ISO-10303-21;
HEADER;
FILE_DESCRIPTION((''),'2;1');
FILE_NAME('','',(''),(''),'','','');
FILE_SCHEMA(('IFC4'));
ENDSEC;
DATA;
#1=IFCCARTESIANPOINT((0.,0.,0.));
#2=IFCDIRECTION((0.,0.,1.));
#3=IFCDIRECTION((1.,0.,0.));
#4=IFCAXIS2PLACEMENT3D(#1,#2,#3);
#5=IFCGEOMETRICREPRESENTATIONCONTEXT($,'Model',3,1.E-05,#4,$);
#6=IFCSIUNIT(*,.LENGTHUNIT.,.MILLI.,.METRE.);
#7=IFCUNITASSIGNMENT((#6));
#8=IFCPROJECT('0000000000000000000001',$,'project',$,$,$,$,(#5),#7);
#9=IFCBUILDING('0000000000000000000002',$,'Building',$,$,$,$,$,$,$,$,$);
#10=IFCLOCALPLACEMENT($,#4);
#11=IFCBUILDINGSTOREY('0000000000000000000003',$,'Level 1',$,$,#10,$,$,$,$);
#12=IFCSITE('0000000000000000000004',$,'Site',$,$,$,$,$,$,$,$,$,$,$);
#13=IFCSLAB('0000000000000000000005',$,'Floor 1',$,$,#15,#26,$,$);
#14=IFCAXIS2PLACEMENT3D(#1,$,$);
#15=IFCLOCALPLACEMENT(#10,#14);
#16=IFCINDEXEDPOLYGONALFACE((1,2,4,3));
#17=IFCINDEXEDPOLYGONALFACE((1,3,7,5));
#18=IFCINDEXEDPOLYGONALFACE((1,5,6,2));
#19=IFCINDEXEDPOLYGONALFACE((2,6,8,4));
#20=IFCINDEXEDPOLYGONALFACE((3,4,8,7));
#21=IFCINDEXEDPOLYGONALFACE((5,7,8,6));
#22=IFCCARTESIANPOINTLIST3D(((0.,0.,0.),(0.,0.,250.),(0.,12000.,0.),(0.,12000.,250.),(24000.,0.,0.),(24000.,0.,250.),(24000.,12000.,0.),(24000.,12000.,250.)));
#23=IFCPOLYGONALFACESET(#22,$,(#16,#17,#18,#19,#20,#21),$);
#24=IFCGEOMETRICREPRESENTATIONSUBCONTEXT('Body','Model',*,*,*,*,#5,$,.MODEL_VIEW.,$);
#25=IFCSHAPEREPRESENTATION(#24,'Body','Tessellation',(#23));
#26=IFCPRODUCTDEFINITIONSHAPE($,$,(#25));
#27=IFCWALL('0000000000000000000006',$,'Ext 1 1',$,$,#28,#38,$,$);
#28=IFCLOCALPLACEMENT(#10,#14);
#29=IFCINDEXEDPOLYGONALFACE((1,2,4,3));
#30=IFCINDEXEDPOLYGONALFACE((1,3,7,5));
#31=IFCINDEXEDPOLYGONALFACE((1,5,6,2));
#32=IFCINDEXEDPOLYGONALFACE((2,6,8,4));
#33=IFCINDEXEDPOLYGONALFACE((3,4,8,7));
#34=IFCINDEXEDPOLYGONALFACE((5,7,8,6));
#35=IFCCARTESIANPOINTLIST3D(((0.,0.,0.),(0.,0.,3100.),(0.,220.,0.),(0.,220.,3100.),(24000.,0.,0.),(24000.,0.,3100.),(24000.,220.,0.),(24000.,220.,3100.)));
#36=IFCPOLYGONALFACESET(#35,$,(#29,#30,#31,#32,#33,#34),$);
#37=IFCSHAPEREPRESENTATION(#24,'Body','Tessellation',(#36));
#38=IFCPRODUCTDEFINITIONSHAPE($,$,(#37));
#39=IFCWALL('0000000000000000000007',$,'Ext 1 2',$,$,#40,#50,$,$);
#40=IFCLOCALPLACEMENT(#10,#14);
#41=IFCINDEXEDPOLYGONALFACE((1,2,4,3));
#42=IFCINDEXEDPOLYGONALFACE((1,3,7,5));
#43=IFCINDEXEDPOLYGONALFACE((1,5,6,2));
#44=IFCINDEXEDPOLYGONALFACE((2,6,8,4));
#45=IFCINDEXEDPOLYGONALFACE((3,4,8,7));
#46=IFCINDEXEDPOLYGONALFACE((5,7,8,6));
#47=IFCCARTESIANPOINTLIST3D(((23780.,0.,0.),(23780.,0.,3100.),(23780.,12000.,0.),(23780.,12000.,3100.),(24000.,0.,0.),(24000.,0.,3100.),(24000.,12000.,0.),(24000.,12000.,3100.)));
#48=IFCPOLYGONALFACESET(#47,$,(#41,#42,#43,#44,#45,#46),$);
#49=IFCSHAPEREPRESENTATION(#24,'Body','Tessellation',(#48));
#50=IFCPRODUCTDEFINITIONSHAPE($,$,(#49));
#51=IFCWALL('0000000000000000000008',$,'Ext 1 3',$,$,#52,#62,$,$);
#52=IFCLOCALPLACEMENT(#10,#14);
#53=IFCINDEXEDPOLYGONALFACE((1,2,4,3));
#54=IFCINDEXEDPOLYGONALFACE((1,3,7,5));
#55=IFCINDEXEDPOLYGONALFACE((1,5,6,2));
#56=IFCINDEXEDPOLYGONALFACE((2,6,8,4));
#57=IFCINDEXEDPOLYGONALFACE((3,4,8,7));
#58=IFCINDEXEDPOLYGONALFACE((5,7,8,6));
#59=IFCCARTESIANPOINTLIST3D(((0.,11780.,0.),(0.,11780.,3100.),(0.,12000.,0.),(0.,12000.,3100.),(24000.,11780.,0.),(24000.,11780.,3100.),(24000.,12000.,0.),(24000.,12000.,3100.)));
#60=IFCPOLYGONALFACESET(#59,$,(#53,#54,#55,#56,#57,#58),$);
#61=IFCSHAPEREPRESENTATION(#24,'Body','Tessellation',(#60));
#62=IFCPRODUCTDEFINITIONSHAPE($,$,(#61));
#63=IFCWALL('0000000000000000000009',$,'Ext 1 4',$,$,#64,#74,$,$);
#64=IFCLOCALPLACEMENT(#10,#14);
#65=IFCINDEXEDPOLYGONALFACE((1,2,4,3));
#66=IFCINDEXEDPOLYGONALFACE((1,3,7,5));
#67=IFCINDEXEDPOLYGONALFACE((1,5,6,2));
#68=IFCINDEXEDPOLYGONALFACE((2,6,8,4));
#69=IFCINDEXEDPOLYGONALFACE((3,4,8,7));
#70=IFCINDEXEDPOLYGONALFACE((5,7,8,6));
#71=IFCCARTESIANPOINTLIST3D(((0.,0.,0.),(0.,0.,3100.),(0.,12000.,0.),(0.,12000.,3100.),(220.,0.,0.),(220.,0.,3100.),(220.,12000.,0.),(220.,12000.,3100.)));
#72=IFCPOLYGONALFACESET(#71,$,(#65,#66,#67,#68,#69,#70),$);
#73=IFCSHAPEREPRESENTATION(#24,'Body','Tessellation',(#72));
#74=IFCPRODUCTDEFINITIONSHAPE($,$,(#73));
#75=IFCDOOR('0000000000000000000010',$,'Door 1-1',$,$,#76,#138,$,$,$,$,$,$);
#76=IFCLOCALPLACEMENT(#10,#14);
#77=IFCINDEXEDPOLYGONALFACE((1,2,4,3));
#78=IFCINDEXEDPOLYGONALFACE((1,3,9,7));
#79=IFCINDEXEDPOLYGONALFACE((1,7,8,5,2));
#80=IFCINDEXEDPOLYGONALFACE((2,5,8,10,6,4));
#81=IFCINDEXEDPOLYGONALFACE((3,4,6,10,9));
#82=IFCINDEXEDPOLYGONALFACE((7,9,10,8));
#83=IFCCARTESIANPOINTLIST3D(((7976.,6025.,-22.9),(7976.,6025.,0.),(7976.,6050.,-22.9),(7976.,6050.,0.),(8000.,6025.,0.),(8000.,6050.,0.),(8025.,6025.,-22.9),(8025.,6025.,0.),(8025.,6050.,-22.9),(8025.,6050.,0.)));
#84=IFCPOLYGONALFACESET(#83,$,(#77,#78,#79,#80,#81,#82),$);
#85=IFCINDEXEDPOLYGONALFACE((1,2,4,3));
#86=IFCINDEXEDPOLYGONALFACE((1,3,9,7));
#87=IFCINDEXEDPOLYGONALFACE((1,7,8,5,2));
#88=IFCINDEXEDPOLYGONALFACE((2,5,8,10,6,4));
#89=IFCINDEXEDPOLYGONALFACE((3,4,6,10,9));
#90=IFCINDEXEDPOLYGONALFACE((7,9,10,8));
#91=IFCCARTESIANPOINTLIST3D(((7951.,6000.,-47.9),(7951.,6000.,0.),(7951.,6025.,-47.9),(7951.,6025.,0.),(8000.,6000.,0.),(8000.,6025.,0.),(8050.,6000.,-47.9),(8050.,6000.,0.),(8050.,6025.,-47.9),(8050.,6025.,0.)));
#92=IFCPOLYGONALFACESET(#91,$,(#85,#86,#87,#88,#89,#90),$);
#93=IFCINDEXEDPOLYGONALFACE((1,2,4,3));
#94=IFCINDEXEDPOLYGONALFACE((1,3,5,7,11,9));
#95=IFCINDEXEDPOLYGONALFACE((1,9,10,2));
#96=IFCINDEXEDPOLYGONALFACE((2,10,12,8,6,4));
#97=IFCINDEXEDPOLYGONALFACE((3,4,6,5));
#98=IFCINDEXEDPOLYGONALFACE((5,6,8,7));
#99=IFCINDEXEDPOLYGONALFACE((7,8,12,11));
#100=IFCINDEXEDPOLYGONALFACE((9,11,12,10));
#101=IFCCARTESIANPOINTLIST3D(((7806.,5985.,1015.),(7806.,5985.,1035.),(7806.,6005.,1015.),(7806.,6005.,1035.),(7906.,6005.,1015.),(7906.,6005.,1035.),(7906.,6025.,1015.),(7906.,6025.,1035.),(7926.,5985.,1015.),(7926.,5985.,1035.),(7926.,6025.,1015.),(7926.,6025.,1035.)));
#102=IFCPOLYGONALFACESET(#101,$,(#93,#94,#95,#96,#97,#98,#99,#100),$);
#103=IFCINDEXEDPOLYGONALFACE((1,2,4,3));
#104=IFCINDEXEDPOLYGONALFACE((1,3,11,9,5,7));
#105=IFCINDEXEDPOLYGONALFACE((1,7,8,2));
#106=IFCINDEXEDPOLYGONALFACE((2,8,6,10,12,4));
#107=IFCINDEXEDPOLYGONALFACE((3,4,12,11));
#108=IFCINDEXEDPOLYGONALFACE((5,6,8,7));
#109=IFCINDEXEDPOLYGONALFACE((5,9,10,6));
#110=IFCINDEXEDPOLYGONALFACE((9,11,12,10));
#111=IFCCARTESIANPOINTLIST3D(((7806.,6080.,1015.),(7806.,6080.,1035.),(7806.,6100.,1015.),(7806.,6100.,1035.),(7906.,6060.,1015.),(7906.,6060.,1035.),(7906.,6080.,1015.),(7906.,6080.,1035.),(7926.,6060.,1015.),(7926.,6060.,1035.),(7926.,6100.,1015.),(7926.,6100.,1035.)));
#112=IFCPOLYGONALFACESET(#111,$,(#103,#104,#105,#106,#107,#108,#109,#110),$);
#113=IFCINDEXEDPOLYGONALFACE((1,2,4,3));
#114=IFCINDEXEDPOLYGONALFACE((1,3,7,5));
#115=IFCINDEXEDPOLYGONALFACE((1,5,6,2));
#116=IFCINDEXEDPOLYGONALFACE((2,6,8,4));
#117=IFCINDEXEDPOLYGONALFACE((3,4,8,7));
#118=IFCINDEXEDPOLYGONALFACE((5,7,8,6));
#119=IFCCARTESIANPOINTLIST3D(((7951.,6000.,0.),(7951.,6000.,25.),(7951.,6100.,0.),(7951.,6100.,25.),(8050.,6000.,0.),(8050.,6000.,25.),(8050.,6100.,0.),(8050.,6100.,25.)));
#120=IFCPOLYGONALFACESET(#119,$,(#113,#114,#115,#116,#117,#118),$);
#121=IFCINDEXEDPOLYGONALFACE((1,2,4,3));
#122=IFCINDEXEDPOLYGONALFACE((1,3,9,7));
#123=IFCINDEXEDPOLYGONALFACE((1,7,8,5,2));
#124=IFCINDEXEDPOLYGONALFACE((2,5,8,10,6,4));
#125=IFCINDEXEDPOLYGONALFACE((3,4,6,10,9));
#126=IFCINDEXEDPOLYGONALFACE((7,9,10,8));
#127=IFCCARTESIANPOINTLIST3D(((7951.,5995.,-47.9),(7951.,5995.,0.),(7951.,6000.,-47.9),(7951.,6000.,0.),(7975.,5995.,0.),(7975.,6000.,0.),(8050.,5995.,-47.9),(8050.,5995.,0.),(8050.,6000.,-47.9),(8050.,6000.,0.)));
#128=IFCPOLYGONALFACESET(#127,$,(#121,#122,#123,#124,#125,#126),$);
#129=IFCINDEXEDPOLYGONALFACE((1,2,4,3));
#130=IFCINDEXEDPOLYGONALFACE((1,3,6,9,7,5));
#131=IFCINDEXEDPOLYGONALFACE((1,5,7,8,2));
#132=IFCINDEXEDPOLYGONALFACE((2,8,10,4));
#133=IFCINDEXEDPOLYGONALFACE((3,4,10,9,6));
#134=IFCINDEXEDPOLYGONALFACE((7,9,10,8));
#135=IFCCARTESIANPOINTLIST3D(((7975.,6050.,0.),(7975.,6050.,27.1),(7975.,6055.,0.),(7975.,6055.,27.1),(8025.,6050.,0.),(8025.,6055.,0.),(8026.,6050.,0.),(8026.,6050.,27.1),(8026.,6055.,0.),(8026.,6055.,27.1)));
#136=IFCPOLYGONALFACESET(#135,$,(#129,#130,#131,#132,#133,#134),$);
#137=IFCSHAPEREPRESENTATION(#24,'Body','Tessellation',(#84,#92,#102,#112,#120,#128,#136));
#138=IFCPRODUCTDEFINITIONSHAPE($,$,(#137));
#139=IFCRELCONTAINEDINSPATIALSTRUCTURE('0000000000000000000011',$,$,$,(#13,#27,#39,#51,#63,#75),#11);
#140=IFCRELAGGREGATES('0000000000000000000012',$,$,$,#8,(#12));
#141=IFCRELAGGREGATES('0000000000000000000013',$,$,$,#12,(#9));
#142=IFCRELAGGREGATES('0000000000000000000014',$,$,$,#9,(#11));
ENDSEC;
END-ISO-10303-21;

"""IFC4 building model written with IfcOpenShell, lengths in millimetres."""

from ifc_helpers import new_model, si_unit, frame, origin_with_axes, place, context, subcontext, project, spatial, line, indexed_curve, outline, extrude, element, save


model = new_model("IFC4")

# Units and contexts
model_context = context("Model", 3, precision=1e-05, world=origin_with_axes())
body_context = subcontext(model_context, "Body", "Model", "MODEL_VIEW")
ifc_project = project(units=[si_unit("LENGTHUNIT", "METRE", prefix="MILLI")], contexts=[model_context])

# Site, building, storey
site = spatial("IfcSite", under=ifc_project, Name="Site")
building = spatial("IfcBuilding", under=site, Name="Building")
storey_placement = place(None, origin_with_axes())
storey = spatial("IfcBuildingStorey", under=building, at=storey_placement, Name="Level 1")

# Slab
slab_placement = place(storey_placement, origin_with_axes())
element("IfcSlab", 1, at=slab_placement, inside=storey, Name="Floor 1", context=body_context, shape_type="SweptSolid", body=[
    extrude(outline(indexed_curve([(0.0, 0.0), (24000.0, 0.0), (24000.0, 12000.0), (0.0, 12000.0), (0.0, 0.0)])), None, (0.0, 0.0, 1.0), 250.0),
])

# Walls
wall_1_placement = place(storey_placement, origin_with_axes())
element("IfcWall", 2, at=wall_1_placement, inside=storey, Name="Ext 1 1", context=body_context, shape_type="SweptSolid", body=[
    extrude(outline(indexed_curve([(0.0, 0.0), (0.0, 220.0), (24000.0, 220.0), (24000.0, 0.0), (0.0, 0.0)], self_intersect=False)), origin_with_axes(), (0.0, 0.0, 1.0), 3100.0),
])
wall_2_placement = place(storey_placement, frame((24000.0, 0.0, 0.0), z_axis=(0.0, 0.0, 1.0), x_axis=(0.0, 1.0, 0.0)))
element("IfcWall", 3, at=wall_2_placement, inside=storey, Name="Ext 1 2", context=body_context, shape_type="SweptSolid", body=[
    extrude(outline(indexed_curve([(0.0, 0.0), (0.0, 220.0), (12000.0, 220.0), (12000.0, 0.0), (0.0, 0.0)], self_intersect=False)), origin_with_axes(), (0.0, 0.0, 1.0), 3100.0),
])
wall_3_placement = place(storey_placement, frame((24000.0, 12000.0, 0.0), z_axis=(0.0, 0.0, 1.0), x_axis=(-1.0, 0.0, 0.0)))
element("IfcWall", 4, at=wall_3_placement, inside=storey, Name="Ext 1 3", context=body_context, shape_type="SweptSolid", body=[
    extrude(outline(indexed_curve([(0.0, 0.0), (0.0, 220.0), (24000.0, 220.0), (24000.0, 0.0), (0.0, 0.0)], self_intersect=False)), origin_with_axes(), (0.0, 0.0, 1.0), 3100.0),
])
wall_4_placement = place(storey_placement, frame((0.0, 12000.0, 0.0), z_axis=(0.0, 0.0, 1.0), x_axis=(0.0, -1.0, 0.0)))
element("IfcWall", 5, at=wall_4_placement, inside=storey, Name="Ext 1 4", context=body_context, shape_type="SweptSolid", body=[
    extrude(outline(indexed_curve([(0.0, 0.0), (0.0, 220.0), (12000.0, 220.0), (12000.0, 0.0), (0.0, 0.0)], self_intersect=False)), origin_with_axes(), (0.0, 0.0, 1.0), 3100.0),
])

# Door
door_1_placement = place(storey_placement, frame((8000.0, 6000.0, 0.0), z_axis=(0.0, 0.0, 1.0), x_axis=(1.0, 0.0, 0.0)))
element("IfcDoor", 6, at=door_1_placement, inside=storey, Name="Door 1-1", context=body_context, shape_type="SweptSolid", body=[
    extrude(outline(indexed_curve([(0.0, 0.0), (0.0, 2.1), (1.0, 2.1), (1.0, 0.0), (-24.0, 0.0), (-24.0, -22.9), (25.0, -22.9), (25.0, 0.0)], segments=[line(1, 2, 3, 4, 5, 6, 7, 8, 1)])), frame((0.0, 25.0, 0.0), z_axis=(0.0, -1.0, 0.0), x_axis=(1.0, 0.0, 0.0)), (0.0, 0.0, -1.0), 25.0),
    extrude(outline(indexed_curve([(0.0, 0.0), (0.0, 2.1), (1.0, 2.1), (1.0, 0.0), (-49.0, 0.0), (-49.0, -47.9), (50.0, -47.9), (50.0, 0.0)], segments=[line(1, 2, 3, 4, 5, 6, 7, 8, 1)])), frame((0.0, 0.0, 0.0), z_axis=(0.0, -1.0, 0.0), x_axis=(1.0, 0.0, 0.0)), (0.0, 0.0, -1.0), 25.0),
    extrude(outline(indexed_curve([(0.0, 0.0), (-49.0, 0.0), (-49.0, 35.0), (0.0, 35.0)], segments=[line(1, 2, 3, 4, 1)])), frame((25.0, 25.0, 25.0), z_axis=(0.0, 0.0, 1.0), x_axis=(1.0, 0.0, 0.0)), (0.0, 0.0, 1.0), -47.9),
    extrude(outline(indexed_curve([(0.0, 0.0), (0.0, -40.0), (-120.0, -40.0), (-120.0, -20.0), (-20.0, -20.0), (-20.0, 0.0)], segments=[line(1, 2, 3, 4, 5, 6, 1)])), frame((-74.0, 25.0, 1015.0), z_axis=(0.0, 0.0, 1.0), x_axis=(1.0, 0.0, 0.0)), (0.0, 0.0, 1.0), 20.0),
    extrude(outline(indexed_curve([(0.0, 0.0), (0.0, 40.0), (-120.0, 40.0), (-120.0, 20.0), (-20.0, 20.0), (-20.0, 0.0)], segments=[line(1, 2, 3, 4, 5, 6, 1)])), frame((-74.0, 60.0, 1015.0), z_axis=(0.0, 0.0, 1.0), x_axis=(1.0, 0.0, 0.0)), (0.0, 0.0, 1.0), 20.0),
    extrude(outline(indexed_curve([(0.0, 0.0), (-99.0, 0.0), (-99.0, 100.0), (0.0, 100.0)], segments=[line(1, 2, 3, 4, 1)])), frame((50.0, 0.0, 0.0), z_axis=(0.0, 0.0, 1.0), x_axis=(1.0, 0.0, 0.0)), (0.0, 0.0, 1.0), 25.0),
    extrude(outline(indexed_curve([(0.0, 0.0), (0.0, 27.1), (51.0, 27.1), (51.0, 0.0), (-24.0, 0.0), (-24.0, -47.9), (75.0, -47.9), (75.0, 0.0)], segments=[line(1, 2, 3, 4, 5, 6, 7, 8, 1)])), frame((-25.0, -5.0, 0.0), z_axis=(0.0, -1.0, 0.0), x_axis=(1.0, 0.0, 0.0)), (0.0, 0.0, -1.0), 5.0),
    extrude(outline(indexed_curve([(0.0, 0.0), (0.0, 27.1), (51.0, 27.1), (51.0, 0.0), (1.0, 0.0), (1.0, -22.9), (50.0, -22.9), (50.0, 0.0)], segments=[line(1, 2, 3, 4, 5, 6, 7, 8, 1)])), frame((-25.0, 50.0, 0.0), z_axis=(0.0, -1.0, 0.0), x_axis=(1.0, 0.0, 0.0)), (0.0, 0.0, -1.0), 5.0),
])

save(model, "model.ifc")
